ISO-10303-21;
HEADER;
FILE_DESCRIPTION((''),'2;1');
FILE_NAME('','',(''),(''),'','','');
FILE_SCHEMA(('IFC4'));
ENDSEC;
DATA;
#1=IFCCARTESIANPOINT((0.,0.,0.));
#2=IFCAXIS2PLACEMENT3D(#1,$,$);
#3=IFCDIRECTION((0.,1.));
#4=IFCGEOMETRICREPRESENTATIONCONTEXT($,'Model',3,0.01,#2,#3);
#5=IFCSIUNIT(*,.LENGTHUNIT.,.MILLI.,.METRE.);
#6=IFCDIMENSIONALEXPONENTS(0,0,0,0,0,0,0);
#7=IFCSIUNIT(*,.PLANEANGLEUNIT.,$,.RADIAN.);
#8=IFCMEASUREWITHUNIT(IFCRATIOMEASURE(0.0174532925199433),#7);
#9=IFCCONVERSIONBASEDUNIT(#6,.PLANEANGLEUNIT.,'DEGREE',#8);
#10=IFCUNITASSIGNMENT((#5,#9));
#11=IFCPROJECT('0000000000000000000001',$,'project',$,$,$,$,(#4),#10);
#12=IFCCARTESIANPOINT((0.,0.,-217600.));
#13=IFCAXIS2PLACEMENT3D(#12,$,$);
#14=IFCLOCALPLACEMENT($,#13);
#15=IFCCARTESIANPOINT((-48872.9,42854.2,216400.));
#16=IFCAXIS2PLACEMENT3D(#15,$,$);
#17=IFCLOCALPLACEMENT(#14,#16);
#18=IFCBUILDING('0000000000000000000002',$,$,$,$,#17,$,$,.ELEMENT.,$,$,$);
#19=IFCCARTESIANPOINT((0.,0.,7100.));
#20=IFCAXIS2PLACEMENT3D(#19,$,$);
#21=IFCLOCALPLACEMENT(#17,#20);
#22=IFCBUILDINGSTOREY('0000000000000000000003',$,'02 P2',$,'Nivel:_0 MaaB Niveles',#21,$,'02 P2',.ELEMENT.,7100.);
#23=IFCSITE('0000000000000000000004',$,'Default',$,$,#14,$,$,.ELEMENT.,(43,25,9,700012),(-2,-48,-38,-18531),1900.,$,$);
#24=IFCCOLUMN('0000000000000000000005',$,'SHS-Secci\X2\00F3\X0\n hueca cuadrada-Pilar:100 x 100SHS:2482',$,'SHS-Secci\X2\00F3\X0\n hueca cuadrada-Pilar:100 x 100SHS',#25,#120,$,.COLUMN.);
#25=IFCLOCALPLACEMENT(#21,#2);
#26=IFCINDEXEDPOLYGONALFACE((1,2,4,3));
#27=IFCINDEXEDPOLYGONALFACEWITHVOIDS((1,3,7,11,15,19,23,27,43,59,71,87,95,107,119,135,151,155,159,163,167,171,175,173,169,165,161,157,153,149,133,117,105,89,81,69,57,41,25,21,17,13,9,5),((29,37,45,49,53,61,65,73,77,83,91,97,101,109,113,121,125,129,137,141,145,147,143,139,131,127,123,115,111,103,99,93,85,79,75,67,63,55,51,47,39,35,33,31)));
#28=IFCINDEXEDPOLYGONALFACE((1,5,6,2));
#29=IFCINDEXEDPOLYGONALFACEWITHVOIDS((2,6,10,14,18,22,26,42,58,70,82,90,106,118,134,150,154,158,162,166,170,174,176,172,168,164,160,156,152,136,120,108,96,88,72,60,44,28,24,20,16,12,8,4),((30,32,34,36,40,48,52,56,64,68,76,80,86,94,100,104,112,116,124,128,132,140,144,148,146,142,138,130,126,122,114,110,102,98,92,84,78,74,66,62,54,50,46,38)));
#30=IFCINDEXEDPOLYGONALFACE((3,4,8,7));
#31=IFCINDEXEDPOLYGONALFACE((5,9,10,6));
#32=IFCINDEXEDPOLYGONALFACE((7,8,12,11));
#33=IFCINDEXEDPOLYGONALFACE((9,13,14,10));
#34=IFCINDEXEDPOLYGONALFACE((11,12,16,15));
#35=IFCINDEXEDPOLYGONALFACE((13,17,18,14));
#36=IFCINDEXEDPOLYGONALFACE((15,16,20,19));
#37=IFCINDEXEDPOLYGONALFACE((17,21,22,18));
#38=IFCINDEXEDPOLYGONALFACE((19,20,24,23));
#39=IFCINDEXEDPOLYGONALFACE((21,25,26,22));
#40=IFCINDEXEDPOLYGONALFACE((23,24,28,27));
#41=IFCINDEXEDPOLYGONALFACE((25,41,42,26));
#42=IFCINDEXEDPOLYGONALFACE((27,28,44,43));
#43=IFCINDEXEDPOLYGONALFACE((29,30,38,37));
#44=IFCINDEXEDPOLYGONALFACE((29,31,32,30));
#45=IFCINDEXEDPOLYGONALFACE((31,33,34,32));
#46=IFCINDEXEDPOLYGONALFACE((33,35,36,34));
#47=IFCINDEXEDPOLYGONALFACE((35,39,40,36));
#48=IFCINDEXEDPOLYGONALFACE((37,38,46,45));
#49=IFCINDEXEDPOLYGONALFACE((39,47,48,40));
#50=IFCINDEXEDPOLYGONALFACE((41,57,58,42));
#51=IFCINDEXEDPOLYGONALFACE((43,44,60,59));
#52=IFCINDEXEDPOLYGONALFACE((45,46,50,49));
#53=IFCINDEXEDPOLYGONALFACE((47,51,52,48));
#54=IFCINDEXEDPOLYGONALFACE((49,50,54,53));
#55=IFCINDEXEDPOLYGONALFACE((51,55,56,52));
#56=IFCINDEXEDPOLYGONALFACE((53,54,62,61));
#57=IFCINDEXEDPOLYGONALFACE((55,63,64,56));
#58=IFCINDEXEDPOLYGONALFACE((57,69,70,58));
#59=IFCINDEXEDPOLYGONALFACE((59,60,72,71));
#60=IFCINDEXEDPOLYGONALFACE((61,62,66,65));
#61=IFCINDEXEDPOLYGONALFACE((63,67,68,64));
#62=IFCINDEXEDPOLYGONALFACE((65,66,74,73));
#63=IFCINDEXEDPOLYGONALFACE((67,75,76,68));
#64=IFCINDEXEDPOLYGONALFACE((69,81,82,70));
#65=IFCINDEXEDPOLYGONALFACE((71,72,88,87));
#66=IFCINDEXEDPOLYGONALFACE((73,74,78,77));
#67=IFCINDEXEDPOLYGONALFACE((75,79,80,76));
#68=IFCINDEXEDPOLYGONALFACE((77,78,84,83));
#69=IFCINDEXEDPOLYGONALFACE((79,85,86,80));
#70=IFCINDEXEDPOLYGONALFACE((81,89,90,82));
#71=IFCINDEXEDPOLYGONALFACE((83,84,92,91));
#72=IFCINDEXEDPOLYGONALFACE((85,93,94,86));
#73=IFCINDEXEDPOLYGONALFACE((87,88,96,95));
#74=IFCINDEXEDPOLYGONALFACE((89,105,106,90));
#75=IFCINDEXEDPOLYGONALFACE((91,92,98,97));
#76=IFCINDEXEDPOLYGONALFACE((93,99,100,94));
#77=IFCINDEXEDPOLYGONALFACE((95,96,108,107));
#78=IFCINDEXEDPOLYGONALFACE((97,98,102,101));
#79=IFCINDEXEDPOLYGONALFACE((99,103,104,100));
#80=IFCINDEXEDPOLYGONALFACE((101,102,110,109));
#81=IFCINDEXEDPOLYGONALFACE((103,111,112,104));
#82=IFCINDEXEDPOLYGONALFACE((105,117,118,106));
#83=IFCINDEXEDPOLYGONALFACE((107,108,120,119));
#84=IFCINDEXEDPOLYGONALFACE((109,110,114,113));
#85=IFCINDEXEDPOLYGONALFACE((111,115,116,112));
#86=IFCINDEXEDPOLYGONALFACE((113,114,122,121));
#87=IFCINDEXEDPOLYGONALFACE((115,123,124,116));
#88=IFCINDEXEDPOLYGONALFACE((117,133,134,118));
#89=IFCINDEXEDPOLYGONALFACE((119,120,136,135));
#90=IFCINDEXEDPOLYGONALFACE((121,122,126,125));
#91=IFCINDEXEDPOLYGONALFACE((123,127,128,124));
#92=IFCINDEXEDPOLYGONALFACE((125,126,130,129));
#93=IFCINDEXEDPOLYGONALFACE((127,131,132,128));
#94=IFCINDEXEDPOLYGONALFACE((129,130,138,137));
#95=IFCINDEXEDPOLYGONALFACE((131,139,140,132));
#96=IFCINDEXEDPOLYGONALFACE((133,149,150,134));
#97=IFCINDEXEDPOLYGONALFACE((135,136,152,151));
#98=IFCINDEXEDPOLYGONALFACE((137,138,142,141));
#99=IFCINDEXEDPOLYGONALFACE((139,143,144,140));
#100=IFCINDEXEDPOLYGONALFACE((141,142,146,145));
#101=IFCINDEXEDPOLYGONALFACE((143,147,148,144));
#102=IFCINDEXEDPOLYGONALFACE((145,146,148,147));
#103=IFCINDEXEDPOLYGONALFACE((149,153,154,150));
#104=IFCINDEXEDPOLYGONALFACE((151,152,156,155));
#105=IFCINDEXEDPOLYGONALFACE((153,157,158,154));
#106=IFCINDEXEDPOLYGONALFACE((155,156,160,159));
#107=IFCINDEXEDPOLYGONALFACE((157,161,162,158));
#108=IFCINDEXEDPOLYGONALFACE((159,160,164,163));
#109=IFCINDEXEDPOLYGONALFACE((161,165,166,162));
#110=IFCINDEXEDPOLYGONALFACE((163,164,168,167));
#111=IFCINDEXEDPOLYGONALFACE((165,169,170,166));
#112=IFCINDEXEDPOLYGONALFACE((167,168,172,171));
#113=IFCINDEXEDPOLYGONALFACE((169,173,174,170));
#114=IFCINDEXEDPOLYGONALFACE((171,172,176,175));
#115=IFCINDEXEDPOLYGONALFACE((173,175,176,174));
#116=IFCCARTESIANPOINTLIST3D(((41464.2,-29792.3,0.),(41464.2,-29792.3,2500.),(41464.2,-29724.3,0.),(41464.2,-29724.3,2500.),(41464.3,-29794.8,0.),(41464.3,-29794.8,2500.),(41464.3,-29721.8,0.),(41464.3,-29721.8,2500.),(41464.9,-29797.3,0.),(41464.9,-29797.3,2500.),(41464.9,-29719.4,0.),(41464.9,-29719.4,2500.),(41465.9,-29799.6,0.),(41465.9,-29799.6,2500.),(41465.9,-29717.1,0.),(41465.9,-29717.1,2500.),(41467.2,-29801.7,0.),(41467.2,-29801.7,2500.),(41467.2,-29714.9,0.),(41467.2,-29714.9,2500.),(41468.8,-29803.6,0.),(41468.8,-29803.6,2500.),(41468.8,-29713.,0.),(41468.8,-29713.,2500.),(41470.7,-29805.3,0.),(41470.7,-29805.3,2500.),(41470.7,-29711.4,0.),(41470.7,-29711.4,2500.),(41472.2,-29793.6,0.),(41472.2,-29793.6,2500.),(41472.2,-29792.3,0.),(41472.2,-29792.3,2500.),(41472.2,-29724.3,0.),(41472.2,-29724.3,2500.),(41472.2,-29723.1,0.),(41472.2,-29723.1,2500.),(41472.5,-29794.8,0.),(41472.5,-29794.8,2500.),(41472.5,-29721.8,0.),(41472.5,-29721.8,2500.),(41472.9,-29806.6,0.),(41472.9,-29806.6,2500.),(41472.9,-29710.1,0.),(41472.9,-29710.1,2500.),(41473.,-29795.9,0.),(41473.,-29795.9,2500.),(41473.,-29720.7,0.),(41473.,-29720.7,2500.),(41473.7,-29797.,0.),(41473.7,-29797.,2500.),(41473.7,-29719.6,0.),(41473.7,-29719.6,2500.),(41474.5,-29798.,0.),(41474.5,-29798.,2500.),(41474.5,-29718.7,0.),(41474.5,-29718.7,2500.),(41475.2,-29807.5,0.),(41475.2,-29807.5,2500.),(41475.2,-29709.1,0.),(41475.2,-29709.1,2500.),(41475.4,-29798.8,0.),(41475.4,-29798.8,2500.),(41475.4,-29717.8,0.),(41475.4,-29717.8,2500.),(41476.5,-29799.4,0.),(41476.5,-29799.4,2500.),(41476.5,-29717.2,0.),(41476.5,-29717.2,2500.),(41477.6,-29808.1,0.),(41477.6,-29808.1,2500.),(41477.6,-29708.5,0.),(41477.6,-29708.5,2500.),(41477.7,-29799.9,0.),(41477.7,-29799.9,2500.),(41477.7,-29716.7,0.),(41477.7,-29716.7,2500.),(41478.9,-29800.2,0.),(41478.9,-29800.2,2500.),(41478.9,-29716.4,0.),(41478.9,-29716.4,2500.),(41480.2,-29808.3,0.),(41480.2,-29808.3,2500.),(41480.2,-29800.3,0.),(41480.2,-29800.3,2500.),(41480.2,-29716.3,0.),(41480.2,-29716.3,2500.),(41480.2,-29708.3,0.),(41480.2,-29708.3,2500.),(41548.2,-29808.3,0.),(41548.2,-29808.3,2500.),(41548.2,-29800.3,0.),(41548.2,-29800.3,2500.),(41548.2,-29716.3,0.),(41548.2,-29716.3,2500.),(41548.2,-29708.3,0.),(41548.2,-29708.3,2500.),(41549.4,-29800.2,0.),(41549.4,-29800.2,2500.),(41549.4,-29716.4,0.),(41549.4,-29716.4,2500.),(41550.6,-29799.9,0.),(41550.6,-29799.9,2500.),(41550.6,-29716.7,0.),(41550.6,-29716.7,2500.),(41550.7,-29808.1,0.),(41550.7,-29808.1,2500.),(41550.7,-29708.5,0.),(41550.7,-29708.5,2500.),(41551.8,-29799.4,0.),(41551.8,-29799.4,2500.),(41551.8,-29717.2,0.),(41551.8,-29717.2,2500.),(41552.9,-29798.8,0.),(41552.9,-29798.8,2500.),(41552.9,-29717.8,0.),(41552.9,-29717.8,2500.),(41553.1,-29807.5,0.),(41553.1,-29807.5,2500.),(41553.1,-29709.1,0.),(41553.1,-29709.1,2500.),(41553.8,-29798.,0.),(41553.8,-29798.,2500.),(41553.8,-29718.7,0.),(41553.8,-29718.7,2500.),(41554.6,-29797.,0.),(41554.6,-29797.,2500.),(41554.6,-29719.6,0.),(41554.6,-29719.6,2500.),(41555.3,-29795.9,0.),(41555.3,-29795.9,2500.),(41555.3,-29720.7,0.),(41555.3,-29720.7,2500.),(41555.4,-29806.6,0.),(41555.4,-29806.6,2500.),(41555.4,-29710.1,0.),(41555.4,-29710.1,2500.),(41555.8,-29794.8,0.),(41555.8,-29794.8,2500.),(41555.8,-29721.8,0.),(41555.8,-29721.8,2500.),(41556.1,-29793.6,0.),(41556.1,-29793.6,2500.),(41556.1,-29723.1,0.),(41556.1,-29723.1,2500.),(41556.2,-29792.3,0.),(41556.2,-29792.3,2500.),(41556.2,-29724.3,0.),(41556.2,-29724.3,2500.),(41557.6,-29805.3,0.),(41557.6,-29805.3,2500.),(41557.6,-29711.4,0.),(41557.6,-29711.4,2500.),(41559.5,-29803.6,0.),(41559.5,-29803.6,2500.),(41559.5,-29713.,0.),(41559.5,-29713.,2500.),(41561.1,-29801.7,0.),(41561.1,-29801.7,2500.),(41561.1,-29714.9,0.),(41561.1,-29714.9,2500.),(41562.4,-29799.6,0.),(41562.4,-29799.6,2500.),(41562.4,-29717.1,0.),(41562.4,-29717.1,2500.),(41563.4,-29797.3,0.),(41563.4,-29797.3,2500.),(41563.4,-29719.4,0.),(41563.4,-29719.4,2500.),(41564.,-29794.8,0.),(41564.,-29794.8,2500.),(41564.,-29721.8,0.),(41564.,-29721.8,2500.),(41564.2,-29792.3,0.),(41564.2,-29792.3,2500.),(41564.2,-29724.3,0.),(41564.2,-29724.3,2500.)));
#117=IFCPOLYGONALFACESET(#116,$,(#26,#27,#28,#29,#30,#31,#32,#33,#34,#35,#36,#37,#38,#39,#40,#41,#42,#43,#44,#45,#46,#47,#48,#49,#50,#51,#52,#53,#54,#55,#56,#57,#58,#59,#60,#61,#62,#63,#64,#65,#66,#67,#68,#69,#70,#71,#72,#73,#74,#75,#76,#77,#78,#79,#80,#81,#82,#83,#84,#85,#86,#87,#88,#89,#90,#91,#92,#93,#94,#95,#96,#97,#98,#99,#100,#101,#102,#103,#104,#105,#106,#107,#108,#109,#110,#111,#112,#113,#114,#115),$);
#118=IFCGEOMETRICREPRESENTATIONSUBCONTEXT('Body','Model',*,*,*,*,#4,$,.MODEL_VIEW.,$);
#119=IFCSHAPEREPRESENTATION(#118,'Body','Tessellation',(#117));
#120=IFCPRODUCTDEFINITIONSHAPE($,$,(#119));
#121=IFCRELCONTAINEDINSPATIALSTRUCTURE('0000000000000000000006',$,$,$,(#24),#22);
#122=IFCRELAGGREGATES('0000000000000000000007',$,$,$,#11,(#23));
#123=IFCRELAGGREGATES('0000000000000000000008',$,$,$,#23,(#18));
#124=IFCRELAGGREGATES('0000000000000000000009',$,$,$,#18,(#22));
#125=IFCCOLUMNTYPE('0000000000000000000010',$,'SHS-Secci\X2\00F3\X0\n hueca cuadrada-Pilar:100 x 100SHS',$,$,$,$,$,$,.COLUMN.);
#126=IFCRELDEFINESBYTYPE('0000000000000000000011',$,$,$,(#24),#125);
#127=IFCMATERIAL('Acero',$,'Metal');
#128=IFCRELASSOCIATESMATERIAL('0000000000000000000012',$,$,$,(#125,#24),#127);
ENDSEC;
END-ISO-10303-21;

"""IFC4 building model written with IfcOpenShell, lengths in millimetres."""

from ifc_helpers import new_model, entity, si_unit, converted_unit, direction, frame, origin, place, context, subcontext, project, spatial, indexed_curve, outline, extrude, source, transform, mapped, material, type_object, type_shapes, element, save


model = new_model("IFC4")

# Units and contexts
model_context = context("Model", 3, precision=0.01, world=origin(), true_north=direction((0.0, 1.0)))
body_context = subcontext(model_context, "Body", "Model", "MODEL_VIEW")
ifc_project = project(units=[si_unit("LENGTHUNIT", "METRE", prefix="MILLI"), converted_unit("PLANEANGLEUNIT", "DEGREE", entity("IfcRatioMeasure", 0.0174532925199433), si_unit("PLANEANGLEUNIT", "RADIAN"), dimensions=[0, 0, 0, 0, 0, 0, 0])], contexts=[model_context])

# Site, building, storey
site_placement = place(None, frame((0.0, 0.0, -217600.0)))
site = spatial("IfcSite", under=ifc_project, at=site_placement, Name="Default", CompositionType="ELEMENT", RefLatitude=(43, 25, 9, 700012), RefLongitude=(-2, -48, -38, -18531), RefElevation=1900.0)
building_placement = place(site_placement, frame((-48872.9, 42854.2, 216400.0)))
building = spatial("IfcBuilding", under=site, at=building_placement, CompositionType="ELEMENT")
storey_placement = place(building_placement, frame((0.0, 0.0, 7100.0)))
storey = spatial("IfcBuildingStorey", under=building, at=storey_placement, Name="02 P2", ObjectType="Nivel:_0 MaaB Niveles", LongName="02 P2", CompositionType="ELEMENT", Elevation=7100.0)

# Column
ifc_material_1 = material(Name="Acero", Category="Metal")
column_type_1 = type_object("IfcColumnType", Name="SHS-Sección hueca cuadrada-Pilar:100 x 100SHS", PredefinedType="COLUMN", material=ifc_material_1)
shared_shape_1 = source(origin(), body_context, "Body", "SweptSolid", [
    extrude(outline(indexed_curve([(-34.0, -50.0), (34.0, -50.0), (36.5, -49.8), (38.9, -49.2), (41.3, -48.3), (43.4, -46.9), (45.3, -45.3), (46.9, -43.4), (48.3, -41.3), (49.2, -38.9), (49.8, -36.5), (50.0, -34.0), (50.0, 34.0), (49.8, 36.5), (49.2, 38.9), (48.3, 41.3), (46.9, 43.4), (45.3, 45.3), (43.4, 46.9), (41.3, 48.3), (38.9, 49.2), (36.5, 49.8), (34.0, 50.0), (-34.0, 50.0), (-36.5, 49.8), (-38.9, 49.2), (-41.3, 48.3), (-43.4, 46.9), (-45.3, 45.3), (-46.9, 43.4), (-48.3, 41.3), (-49.2, 38.9), (-49.8, 36.5), (-50.0, 34.0), (-50.0, -34.0), (-49.8, -36.5), (-49.2, -38.9), (-48.3, -41.3), (-46.9, -43.4), (-45.3, -45.3), (-43.4, -46.9), (-41.3, -48.3), (-38.9, -49.2), (-36.5, -49.8), (-34.0, -50.0)], self_intersect=False), holes=[indexed_curve([(-42.0, 34.0), (-41.9, 35.3), (-41.6, 36.5), (-41.1, 37.6), (-40.5, 38.7), (-39.7, 39.7), (-38.7, 40.5), (-37.6, 41.1), (-36.5, 41.6), (-35.3, 41.9), (-34.0, 42.0), (34.0, 42.0), (35.3, 41.9), (36.5, 41.6), (37.6, 41.1), (38.7, 40.5), (39.7, 39.7), (40.5, 38.7), (41.1, 37.6), (41.6, 36.5), (41.9, 35.3), (42.0, 34.0), (42.0, -34.0), (41.9, -35.3), (41.6, -36.5), (41.1, -37.6), (40.5, -38.7), (39.7, -39.7), (38.7, -40.5), (37.6, -41.1), (36.5, -41.6), (35.3, -41.9), (34.0, -42.0), (-34.0, -42.0), (-35.3, -41.9), (-36.5, -41.6), (-37.6, -41.1), (-38.7, -40.5), (-39.7, -39.7), (-40.5, -38.7), (-41.1, -37.6), (-41.6, -36.5), (-41.9, -35.3), (-42.0, -34.0), (-42.0, 34.0)], self_intersect=False)]), frame((0.0, 0.0, 7100.0), z_axis=(0.0, 0.0, 1.0), x_axis=(0.0, 1.0, 0.0)), (0.0, 0.0, 1.0), 2500.0),
])
type_shapes(column_type_1, [shared_shape_1])
column_1_placement = place(storey_placement, frame((41514.2, -29758.3, -7100.0), z_axis=(0.0, 0.0, 1.0), x_axis=(0.0, -1.0, 0.0)))
element("IfcColumn", 1, at=column_1_placement, inside=storey, type_object=column_type_1, material=ifc_material_1, Name="SHS-Sección hueca cuadrada-Pilar:100 x 100SHS:2482", ObjectType="SHS-Sección hueca cuadrada-Pilar:100 x 100SHS", PredefinedType="COLUMN", context=body_context, shape_type="MappedRepresentation", body=[
    mapped(shared_shape_1, transform((0.0, 0.0, 0.0), scale=1.0)),
])

save(model, "model.ifc")
